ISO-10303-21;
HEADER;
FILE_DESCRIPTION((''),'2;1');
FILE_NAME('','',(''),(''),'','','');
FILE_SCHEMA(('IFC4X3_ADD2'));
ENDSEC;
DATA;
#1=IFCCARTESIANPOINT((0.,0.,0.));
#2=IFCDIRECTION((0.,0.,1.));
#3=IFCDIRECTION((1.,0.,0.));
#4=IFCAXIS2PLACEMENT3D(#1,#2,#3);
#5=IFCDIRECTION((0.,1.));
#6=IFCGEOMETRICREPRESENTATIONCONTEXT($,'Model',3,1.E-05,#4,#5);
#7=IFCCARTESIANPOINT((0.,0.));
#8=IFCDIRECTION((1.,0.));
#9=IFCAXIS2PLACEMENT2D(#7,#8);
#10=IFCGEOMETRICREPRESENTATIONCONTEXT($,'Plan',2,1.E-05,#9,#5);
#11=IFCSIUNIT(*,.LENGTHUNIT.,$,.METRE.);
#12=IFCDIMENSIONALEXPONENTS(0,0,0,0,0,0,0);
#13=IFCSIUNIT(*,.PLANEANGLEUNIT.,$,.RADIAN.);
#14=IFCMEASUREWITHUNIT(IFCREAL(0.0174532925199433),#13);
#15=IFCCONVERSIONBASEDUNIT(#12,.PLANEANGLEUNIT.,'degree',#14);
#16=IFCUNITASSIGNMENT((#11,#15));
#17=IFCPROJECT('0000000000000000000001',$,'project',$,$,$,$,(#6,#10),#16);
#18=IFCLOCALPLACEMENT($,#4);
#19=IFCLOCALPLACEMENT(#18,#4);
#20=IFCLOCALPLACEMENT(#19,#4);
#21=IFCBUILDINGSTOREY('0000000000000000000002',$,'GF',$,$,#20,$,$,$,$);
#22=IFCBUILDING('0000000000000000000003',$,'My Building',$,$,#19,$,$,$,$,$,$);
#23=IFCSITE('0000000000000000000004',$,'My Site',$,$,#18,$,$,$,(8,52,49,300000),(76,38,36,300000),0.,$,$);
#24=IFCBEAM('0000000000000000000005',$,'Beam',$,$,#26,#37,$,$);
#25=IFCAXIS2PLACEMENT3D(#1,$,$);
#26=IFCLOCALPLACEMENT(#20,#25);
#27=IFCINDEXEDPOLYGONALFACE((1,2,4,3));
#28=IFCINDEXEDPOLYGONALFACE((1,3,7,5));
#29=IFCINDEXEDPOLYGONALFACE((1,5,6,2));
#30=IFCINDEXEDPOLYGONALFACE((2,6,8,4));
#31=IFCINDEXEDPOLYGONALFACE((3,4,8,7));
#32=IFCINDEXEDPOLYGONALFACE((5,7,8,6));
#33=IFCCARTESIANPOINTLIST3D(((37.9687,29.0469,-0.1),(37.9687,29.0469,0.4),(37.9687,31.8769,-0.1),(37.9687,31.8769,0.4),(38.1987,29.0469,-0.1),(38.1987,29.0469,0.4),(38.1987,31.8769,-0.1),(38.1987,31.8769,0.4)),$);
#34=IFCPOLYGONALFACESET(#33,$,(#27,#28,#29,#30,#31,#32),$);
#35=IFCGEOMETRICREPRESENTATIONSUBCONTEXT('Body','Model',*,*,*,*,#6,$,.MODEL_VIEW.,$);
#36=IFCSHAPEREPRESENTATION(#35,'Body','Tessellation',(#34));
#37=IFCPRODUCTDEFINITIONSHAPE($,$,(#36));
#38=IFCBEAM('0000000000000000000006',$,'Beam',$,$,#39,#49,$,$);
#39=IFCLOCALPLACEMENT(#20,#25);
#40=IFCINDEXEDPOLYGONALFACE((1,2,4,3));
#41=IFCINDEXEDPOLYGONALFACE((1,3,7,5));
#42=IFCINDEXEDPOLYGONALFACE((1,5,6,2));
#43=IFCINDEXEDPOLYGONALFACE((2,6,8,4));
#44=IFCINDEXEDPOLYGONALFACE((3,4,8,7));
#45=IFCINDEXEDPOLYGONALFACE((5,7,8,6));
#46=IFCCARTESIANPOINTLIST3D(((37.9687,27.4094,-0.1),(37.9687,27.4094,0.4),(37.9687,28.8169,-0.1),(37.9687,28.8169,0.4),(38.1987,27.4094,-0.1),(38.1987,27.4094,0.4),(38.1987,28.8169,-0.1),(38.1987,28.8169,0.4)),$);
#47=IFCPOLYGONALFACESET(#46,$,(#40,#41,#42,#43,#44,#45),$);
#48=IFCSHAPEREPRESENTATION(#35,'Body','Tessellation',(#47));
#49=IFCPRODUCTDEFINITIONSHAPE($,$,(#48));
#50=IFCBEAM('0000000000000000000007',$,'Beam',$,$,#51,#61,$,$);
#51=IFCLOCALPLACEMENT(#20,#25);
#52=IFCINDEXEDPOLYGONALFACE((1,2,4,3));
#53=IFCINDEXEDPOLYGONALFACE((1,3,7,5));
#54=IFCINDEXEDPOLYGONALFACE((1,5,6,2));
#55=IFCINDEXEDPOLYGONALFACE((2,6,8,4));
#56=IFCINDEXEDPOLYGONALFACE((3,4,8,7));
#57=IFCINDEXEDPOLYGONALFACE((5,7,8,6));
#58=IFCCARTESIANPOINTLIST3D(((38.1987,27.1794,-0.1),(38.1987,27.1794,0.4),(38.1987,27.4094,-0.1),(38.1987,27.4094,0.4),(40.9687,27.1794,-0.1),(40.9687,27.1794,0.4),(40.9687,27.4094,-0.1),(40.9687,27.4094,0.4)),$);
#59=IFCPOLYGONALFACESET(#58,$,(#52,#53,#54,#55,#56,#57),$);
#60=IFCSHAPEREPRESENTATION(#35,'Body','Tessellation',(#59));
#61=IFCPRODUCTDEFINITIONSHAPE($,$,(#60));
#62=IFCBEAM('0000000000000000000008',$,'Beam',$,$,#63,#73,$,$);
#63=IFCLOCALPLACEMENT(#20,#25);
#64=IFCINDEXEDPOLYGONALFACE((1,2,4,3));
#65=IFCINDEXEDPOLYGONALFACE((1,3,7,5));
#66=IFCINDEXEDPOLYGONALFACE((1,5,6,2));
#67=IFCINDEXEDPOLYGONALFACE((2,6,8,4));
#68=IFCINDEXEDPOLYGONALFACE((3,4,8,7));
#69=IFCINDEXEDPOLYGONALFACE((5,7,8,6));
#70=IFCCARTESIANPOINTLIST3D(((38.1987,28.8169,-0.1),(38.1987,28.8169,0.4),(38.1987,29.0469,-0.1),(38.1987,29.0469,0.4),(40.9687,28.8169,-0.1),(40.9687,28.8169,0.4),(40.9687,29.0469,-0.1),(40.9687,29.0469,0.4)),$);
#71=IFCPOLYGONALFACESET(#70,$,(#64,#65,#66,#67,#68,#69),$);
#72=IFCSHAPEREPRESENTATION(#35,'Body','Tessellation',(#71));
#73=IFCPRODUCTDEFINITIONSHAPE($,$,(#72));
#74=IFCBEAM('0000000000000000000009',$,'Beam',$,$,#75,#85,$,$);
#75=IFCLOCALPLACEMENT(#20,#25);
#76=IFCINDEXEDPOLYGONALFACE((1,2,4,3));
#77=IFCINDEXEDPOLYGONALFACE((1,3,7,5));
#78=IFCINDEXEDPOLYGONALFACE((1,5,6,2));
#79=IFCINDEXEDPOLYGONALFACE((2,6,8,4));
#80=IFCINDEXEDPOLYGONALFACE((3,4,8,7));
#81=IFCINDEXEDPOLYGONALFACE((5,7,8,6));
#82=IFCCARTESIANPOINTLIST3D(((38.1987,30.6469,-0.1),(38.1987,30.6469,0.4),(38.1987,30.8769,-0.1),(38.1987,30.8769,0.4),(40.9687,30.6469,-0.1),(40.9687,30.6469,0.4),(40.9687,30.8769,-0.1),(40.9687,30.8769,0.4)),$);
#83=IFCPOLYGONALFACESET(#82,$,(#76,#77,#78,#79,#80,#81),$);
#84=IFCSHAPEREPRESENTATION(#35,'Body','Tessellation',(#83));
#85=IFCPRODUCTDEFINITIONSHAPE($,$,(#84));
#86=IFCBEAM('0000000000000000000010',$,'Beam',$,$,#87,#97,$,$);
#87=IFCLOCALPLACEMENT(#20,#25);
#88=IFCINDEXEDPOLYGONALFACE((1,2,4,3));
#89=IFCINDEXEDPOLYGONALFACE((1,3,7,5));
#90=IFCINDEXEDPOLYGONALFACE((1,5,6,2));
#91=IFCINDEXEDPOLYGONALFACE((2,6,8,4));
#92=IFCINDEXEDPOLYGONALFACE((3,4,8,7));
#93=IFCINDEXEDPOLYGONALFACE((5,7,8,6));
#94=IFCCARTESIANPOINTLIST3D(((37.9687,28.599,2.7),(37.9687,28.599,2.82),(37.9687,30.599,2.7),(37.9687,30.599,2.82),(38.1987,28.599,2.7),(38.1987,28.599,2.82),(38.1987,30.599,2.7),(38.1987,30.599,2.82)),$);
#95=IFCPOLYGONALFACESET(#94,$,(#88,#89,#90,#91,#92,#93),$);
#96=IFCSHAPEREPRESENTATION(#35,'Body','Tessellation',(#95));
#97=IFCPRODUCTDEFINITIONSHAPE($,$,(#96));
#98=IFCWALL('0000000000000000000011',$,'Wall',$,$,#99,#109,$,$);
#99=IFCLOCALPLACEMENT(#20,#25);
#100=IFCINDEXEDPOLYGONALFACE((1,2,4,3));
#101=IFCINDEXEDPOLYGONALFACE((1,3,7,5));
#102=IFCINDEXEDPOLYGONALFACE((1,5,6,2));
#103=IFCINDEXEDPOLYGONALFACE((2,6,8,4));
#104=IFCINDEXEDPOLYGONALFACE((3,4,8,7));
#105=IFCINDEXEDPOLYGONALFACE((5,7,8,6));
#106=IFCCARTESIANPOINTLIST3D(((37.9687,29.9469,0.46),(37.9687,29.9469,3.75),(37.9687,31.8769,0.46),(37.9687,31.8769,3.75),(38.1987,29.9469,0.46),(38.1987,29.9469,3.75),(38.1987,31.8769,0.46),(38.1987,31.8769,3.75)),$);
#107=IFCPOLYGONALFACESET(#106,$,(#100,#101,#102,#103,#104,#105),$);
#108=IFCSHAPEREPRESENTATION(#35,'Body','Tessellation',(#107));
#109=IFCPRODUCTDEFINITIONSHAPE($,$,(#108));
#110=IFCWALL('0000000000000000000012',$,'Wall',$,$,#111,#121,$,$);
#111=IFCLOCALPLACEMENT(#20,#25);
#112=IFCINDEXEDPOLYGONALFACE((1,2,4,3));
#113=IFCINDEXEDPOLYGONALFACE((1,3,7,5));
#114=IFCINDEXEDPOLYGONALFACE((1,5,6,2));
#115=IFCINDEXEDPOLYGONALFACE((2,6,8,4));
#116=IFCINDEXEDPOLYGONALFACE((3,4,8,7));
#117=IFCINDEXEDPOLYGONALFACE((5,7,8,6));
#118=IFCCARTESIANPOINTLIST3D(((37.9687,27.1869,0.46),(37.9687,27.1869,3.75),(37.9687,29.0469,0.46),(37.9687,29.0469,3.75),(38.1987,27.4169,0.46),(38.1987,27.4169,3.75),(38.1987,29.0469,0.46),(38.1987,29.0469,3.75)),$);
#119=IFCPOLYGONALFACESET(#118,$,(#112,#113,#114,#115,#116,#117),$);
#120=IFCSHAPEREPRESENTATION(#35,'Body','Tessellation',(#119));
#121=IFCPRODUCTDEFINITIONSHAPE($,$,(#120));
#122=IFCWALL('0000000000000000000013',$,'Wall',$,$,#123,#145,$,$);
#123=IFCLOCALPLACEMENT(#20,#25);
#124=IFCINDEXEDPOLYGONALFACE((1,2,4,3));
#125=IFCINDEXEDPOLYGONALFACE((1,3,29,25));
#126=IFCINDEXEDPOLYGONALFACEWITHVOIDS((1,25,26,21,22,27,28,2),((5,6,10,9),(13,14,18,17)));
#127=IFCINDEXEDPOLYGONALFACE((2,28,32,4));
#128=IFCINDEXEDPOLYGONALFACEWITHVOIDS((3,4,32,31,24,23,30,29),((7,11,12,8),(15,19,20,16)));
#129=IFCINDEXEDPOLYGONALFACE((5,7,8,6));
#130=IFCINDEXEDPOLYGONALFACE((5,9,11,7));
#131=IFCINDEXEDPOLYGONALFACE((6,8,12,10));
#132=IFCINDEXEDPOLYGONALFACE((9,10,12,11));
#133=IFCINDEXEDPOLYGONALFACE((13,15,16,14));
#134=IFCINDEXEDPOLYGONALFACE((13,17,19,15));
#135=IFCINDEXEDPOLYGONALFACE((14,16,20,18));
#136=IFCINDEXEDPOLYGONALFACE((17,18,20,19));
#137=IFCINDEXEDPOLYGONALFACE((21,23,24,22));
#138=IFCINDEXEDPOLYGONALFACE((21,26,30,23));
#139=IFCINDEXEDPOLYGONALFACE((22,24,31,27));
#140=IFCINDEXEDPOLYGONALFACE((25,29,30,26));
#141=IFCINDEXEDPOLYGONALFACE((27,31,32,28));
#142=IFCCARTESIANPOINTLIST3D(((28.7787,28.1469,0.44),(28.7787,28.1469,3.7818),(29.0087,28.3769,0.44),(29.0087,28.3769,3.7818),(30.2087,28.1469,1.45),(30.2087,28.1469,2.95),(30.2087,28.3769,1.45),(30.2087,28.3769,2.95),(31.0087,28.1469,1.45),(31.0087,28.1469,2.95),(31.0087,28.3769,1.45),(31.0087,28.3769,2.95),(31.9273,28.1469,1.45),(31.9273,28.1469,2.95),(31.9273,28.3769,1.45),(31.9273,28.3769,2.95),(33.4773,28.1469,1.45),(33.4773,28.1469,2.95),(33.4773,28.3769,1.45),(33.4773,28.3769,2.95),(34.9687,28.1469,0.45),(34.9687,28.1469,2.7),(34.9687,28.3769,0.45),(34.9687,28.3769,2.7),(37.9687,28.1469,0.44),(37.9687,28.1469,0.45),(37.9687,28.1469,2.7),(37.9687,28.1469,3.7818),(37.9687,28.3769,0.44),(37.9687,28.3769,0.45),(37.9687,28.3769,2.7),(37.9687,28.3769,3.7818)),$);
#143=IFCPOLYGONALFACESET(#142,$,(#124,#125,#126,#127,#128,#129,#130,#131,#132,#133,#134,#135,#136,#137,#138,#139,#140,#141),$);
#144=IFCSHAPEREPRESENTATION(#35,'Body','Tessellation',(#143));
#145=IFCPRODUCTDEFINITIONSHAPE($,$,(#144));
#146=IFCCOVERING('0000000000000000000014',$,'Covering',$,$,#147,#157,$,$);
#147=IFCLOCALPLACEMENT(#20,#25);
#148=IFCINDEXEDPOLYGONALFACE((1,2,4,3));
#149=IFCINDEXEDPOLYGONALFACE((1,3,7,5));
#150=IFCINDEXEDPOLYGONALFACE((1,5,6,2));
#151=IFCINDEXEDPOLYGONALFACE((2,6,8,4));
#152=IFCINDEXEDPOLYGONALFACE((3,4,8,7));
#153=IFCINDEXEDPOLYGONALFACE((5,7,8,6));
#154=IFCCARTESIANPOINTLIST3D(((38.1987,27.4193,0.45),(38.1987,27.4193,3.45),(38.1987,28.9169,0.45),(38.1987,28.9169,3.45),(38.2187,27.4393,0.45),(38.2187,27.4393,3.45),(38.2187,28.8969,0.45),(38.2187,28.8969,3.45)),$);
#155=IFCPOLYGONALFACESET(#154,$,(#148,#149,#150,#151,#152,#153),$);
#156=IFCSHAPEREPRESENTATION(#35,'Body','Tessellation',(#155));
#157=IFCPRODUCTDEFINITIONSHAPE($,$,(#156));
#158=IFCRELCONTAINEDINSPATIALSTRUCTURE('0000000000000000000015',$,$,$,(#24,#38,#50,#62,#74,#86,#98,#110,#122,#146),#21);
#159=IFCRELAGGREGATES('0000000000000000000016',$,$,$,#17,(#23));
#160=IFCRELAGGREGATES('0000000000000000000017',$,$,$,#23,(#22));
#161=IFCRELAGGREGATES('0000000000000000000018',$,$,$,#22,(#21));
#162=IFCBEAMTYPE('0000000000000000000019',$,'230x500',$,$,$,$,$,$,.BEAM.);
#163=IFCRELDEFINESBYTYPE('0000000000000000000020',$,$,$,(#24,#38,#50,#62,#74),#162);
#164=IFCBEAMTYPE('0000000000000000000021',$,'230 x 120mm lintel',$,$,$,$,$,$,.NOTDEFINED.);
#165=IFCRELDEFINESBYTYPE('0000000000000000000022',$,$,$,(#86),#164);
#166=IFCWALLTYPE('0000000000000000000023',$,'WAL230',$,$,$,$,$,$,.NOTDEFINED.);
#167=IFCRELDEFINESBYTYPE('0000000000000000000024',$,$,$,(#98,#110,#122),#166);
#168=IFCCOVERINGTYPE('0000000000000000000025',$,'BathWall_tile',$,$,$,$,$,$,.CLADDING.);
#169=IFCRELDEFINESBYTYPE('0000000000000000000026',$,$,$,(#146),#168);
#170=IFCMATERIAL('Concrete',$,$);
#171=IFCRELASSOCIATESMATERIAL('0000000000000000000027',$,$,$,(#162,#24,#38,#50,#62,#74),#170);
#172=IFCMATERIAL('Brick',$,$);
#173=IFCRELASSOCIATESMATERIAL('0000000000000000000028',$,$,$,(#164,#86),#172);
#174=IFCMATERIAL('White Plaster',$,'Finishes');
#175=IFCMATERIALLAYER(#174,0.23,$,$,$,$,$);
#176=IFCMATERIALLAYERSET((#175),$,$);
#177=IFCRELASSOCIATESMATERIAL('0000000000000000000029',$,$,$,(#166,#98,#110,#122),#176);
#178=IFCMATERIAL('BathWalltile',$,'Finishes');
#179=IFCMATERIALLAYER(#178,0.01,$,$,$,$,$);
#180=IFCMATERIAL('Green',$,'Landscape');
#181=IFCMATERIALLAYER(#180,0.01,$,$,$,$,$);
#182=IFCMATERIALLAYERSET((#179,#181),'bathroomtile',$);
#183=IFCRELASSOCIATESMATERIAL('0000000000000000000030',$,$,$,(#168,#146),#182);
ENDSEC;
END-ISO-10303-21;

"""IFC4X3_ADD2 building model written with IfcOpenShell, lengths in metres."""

from ifc_helpers import new_model, entity, si_unit, converted_unit, direction, frame, origin_with_axes, origin_2d_with_axis, place, context, subcontext, project, spatial, line, indexed_curve, rectangle, outline, extrude, source, transform, mapped, material, layer, layer_set, layer_usage, material_profile, profile_set, profile_usage, type_object, element, save


model = new_model("IFC4X3_ADD2")

# Units and contexts
model_context = context("Model", 3, precision=1e-05, world=origin_with_axes(), true_north=direction((0.0, 1.0)))
plan_context = context("Plan", 2, precision=1e-05, world=origin_2d_with_axis(), true_north=direction((0.0, 1.0)))
body_context_1 = subcontext(model_context, "Body", "Model", "MODEL_VIEW")
ifc_project = project(units=[si_unit("LENGTHUNIT", "METRE"), converted_unit("PLANEANGLEUNIT", "degree", entity("IfcReal", 0.0174532925199433), si_unit("PLANEANGLEUNIT", "RADIAN"), dimensions=[0, 0, 0, 0, 0, 0, 0])], contexts=[model_context, plan_context])

# Site, building, storey
site_placement = place(None, origin_with_axes())
site = spatial("IfcSite", under=ifc_project, at=site_placement, Name="My Site", RefLatitude=(8, 52, 49, 300000), RefLongitude=(76, 38, 36, 300000), RefElevation=0.0)
building_placement = place(site_placement, origin_with_axes())
building = spatial("IfcBuilding", under=site, at=building_placement, Name="My Building")
storey_placement = place(building_placement, origin_with_axes())
storey = spatial("IfcBuildingStorey", under=building, at=storey_placement, Name="GF")

# Beams
ifc_material_1 = material(Name="Concrete")
ifc_material_profile_1 = material_profile(ifc_material_1, rectangle(XDim=0.23, YDim=0.5))
ifc_profile_set_1 = profile_set([ifc_material_profile_1])
ifc_profile_usage_1 = profile_usage(ifc_profile_set_1, cardinal=5)
beam_type_1 = type_object("IfcBeamType", Name="230x500", PredefinedType="BEAM", material=ifc_profile_set_1)
beam_1_placement = place(storey_placement, frame((38.0837, 29.0469, 0.15), z_axis=(0.0, 1.0, 0.0), x_axis=(-1.0, 0.0, 0.0)))
element("IfcBeam", 1, at=beam_1_placement, inside=storey, type_object=beam_type_1, material=ifc_profile_usage_1, Name="Beam", context=body_context_1, shape_type="SweptSolid", body=[
    extrude(rectangle(XDim=0.23, YDim=0.5), origin_with_axes(), (0.0, 0.0, 1.0), 2.83),
])
ifc_profile_usage_2 = profile_usage(ifc_profile_set_1, cardinal=5)
beam_2_placement = place(storey_placement, frame((38.0837, 27.4094, 0.15), z_axis=(0.0, 1.0, 0.0), x_axis=(-1.0, 0.0, 0.0)))
element("IfcBeam", 2, at=beam_2_placement, inside=storey, type_object=beam_type_1, material=ifc_profile_usage_2, Name="Beam", context=body_context_1, shape_type="SweptSolid", body=[
    extrude(rectangle(XDim=0.23, YDim=0.5), origin_with_axes(), (0.0, 0.0, 1.0), 1.4075),
])
ifc_profile_usage_3 = profile_usage(ifc_profile_set_1, cardinal=5)
beam_3_placement = place(storey_placement, frame((38.1987, 27.2944, 0.15), z_axis=(1.0, 0.0, 0.0), x_axis=(0.0, 1.0, 0.0)))
element("IfcBeam", 3, at=beam_3_placement, inside=storey, type_object=beam_type_1, material=ifc_profile_usage_3, Name="Beam", context=body_context_1, shape_type="SweptSolid", body=[
    extrude(rectangle(XDim=0.23, YDim=0.5), origin_with_axes(), (0.0, 0.0, 1.0), 2.77),
])
ifc_profile_usage_4 = profile_usage(ifc_profile_set_1, cardinal=5)
beam_4_placement = place(storey_placement, frame((38.1987, 28.9319, 0.15), z_axis=(1.0, 0.0, 0.0), x_axis=(0.0, 1.0, 0.0)))
element("IfcBeam", 4, at=beam_4_placement, inside=storey, type_object=beam_type_1, material=ifc_profile_usage_4, Name="Beam", context=body_context_1, shape_type="SweptSolid", body=[
    extrude(rectangle(XDim=0.23, YDim=0.5), origin_with_axes(), (0.0, 0.0, 1.0), 2.77),
])
ifc_profile_usage_5 = profile_usage(ifc_profile_set_1, cardinal=5)
beam_5_placement = place(storey_placement, frame((38.1987, 30.7619, 0.15), z_axis=(1.0, 0.0, 0.0), x_axis=(0.0, 1.0, 0.0)))
element("IfcBeam", 5, at=beam_5_placement, inside=storey, type_object=beam_type_1, material=ifc_profile_usage_5, Name="Beam", context=body_context_1, shape_type="SweptSolid", body=[
    extrude(rectangle(XDim=0.23, YDim=0.5), origin_with_axes(), (0.0, 0.0, 1.0), 2.77),
])
ifc_material_2 = material(Name="Brick")
ifc_material_profile_2 = material_profile(ifc_material_2, rectangle(XDim=0.23, YDim=0.12))
ifc_profile_set_2 = profile_set([ifc_material_profile_2], Name="blank")
ifc_profile_usage_6 = profile_usage(ifc_profile_set_2, cardinal=5)
beam_type_2 = type_object("IfcBeamType", Name="230 x 120mm lintel", PredefinedType="NOTDEFINED", material=ifc_profile_set_2)
beam_6_placement = place(storey_placement, frame((38.0837, 30.599, 2.76), z_axis=(0.0, -1.0, 0.0), x_axis=(1.0, 0.0, 0.0)))
element("IfcBeam", 6, at=beam_6_placement, inside=storey, type_object=beam_type_2, material=ifc_profile_usage_6, Name="Beam", context=body_context_1, shape_type="SweptSolid", body=[
    extrude(rectangle(XDim=0.23, YDim=0.12), origin_with_axes(), (0.0, 0.0, 1.0), 2.0),
])

# Walls
ifc_material_3 = material(Name="White Plaster", Category="Finishes")
ifc_layer_1 = layer(ifc_material_3, 0.23)
ifc_layer_set_1 = layer_set([ifc_layer_1])
ifc_layer_usage_1 = layer_usage(ifc_layer_set_1, "AXIS2", "POSITIVE", 0.0)
wall_type = type_object("IfcWallType", Name="WAL230", PredefinedType="NOTDEFINED", material=ifc_layer_set_1)
wall_1_placement = place(storey_placement, frame((38.1987, 29.9469, 0.46), z_axis=(0.0, 0.0, 1.0), x_axis=(0.0, 1.0, 0.0)))
element("IfcWall", 7, at=wall_1_placement, inside=storey, type_object=wall_type, material=ifc_layer_usage_1, Name="Wall", context=body_context_1, shape_type="SweptSolid", body=[
    extrude(outline(indexed_curve([(0.0, 0.0), (0.0, 0.23), (1.93, 0.23), (1.93, 0.0)], segments=[line(1, 2, 3, 4, 1)])), origin_with_axes(), (0.0, 0.0, 1.0), 3.29),
])
ifc_layer_usage_2 = layer_usage(ifc_layer_set_1, "AXIS2", "POSITIVE", 0.0)
wall_2_placement = place(storey_placement, frame((38.1987, 27.4169, 0.46), z_axis=(0.0, 0.0, 1.0), x_axis=(0.0, 1.0, 0.0)))
element("IfcWall", 8, at=wall_2_placement, inside=storey, type_object=wall_type, material=ifc_layer_usage_2, Name="Wall", context=body_context_1, shape_type="SweptSolid", body=[
    extrude(outline(indexed_curve([(0.0, 0.0), (-0.23, 0.23), (1.63, 0.23), (1.63, 0.0)], segments=[line(1, 2, 3, 4, 1)])), origin_with_axes(), (0.0, 0.0, 1.0), 3.29),
])

# Wall, openings
ifc_layer_usage_3 = layer_usage(ifc_layer_set_1, "AXIS2", "POSITIVE", 0.0)
wall_3_placement = place(storey_placement, frame((37.9687, 28.3769, 0.44), z_axis=(0.0, 0.0, 1.0), x_axis=(-1.0, 0.0, 0.0)))
wall_3 = element("IfcWall", 9, at=wall_3_placement, inside=storey, type_object=wall_type, material=ifc_layer_usage_3, Name="Wall", context=body_context_1, shape_type="SweptSolid", body=[
    extrude(outline(indexed_curve([(0.0, 0.0), (0.0, 0.23), (9.19, 0.23), (8.96, 0.0)], segments=[line(1, 2, 3, 4, 1)])), origin_with_axes(), (0.0, 0.0, 1.0), 3.3418),
])
shared_shape_1 = source(origin_with_axes(), body_context_1, "Body", "SweptSolid", [
    extrude(outline(indexed_curve([(0.0, 0.0), (3.0, 0.0), (3.0, 2.25), (0.0, 2.25)], segments=[line(1, 2, 3, 4, 1)])), frame((0.0, -0.6, 0.0), z_axis=(0.0, -1.0, 0.0), x_axis=(1.0, 0.0, 0.0)), (0.0, 0.0, -1.0), 1.2),
])
opening_1_placement = place(wall_3_placement, frame((3.0, 0.1755, 0.01), z_axis=(0.0, 0.0, 1.0), x_axis=(-1.0, 0.0, 0.0)))
element("IfcOpeningElement", 10, at=opening_1_placement, cuts=wall_3, PredefinedType="OPENING", context=body_context_1, shape_type="MappedRepresentation", body=[
    mapped(shared_shape_1, transform((0.0, 0.0, 0.0), x_axis=(1.0, 0.0, 0.0), y_axis=(0.0, 1.0, 0.0), z_axis=(0.0, 0.0, 1.0), scale=1.0)),
])
shared_shape_2 = source(origin_with_axes(), body_context_1, "Body", "SweptSolid", [
    extrude(outline(indexed_curve([(0.0, 0.0), (1.55, 0.0), (1.55, 1.5), (0.0, 1.5)], segments=[line(1, 2, 3, 4, 1)])), frame((0.0, -0.6, 0.0), z_axis=(0.0, -1.0, 0.0), x_axis=(1.0, 0.0, 0.0)), (0.0, 0.0, -1.0), 1.2),
])
opening_2_placement = place(wall_3_placement, frame((4.4915, 0.0, 1.01), z_axis=(0.0, 0.0, 1.0), x_axis=(1.0, 0.0, 0.0)))
element("IfcOpeningElement", 11, at=opening_2_placement, cuts=wall_3, PredefinedType="OPENING", context=body_context_1, shape_type="MappedRepresentation", body=[
    mapped(shared_shape_2, transform((0.0, 0.0, 0.0), x_axis=(1.0, 0.0, 0.0), y_axis=(0.0, 1.0, 0.0), z_axis=(0.0, 0.0, 1.0), scale=1.0)),
])
shared_shape_3 = source(origin_with_axes(), body_context_1, "Body", "SweptSolid", [
    extrude(outline(indexed_curve([(0.0, 0.0), (0.8, 0.0), (0.8, 1.5), (0.0, 1.5)], segments=[line(1, 2, 3, 4, 1)])), frame((0.0, -0.6, 0.0), z_axis=(0.0, -1.0, 0.0), x_axis=(1.0, 0.0, 0.0)), (0.0, 0.0, -1.0), 1.2),
])
opening_3_placement = place(wall_3_placement, frame((7.76, 0.23, 1.01), z_axis=(0.0, 0.0, 1.0), x_axis=(-1.0, 0.0, 0.0)))
element("IfcOpeningElement", 12, at=opening_3_placement, cuts=wall_3, PredefinedType="OPENING", context=body_context_1, shape_type="MappedRepresentation", body=[
    mapped(shared_shape_3, transform((0.0, 0.0, 0.0), x_axis=(1.0, 0.0, 0.0), y_axis=(0.0, 1.0, 0.0), z_axis=(0.0, 0.0, 1.0), scale=1.0)),
])

# Covering
ifc_material_4 = material(Name="BathWalltile", Category="Finishes")
ifc_layer_2 = layer(ifc_material_4, 0.01)
ifc_material_5 = material(Name="Green", Category="Landscape")
ifc_layer_3 = layer(ifc_material_5, 0.01)
ifc_layer_set_2 = layer_set([ifc_layer_2, ifc_layer_3], Name="bathroomtile")
ifc_layer_usage_4 = layer_usage(ifc_layer_set_2, "AXIS2", "POSITIVE", 0.0)
covering_type_1 = type_object("IfcCoveringType", Name="BathWall_tile", PredefinedType="CLADDING", material=ifc_layer_set_2)
covering_1_placement = place(storey_placement, frame((38.2187, 27.4393, 0.45), z_axis=(0.0, 0.0, 1.0), x_axis=(0.0, 1.0, 0.0)))
element("IfcCovering", 13, at=covering_1_placement, inside=storey, type_object=covering_type_1, material=ifc_layer_usage_4, Name="Covering", context=body_context_1, shape_type="SweptSolid", body=[
    extrude(outline(indexed_curve([(0.0, 0.0), (-0.02, 0.02), (1.4776, 0.02), (1.4576, 0.0)], segments=[line(1, 2, 3, 4, 1)])), origin_with_axes(), (0.0, 0.0, 1.0), 3.0),
])

save(model, "model.ifc")
